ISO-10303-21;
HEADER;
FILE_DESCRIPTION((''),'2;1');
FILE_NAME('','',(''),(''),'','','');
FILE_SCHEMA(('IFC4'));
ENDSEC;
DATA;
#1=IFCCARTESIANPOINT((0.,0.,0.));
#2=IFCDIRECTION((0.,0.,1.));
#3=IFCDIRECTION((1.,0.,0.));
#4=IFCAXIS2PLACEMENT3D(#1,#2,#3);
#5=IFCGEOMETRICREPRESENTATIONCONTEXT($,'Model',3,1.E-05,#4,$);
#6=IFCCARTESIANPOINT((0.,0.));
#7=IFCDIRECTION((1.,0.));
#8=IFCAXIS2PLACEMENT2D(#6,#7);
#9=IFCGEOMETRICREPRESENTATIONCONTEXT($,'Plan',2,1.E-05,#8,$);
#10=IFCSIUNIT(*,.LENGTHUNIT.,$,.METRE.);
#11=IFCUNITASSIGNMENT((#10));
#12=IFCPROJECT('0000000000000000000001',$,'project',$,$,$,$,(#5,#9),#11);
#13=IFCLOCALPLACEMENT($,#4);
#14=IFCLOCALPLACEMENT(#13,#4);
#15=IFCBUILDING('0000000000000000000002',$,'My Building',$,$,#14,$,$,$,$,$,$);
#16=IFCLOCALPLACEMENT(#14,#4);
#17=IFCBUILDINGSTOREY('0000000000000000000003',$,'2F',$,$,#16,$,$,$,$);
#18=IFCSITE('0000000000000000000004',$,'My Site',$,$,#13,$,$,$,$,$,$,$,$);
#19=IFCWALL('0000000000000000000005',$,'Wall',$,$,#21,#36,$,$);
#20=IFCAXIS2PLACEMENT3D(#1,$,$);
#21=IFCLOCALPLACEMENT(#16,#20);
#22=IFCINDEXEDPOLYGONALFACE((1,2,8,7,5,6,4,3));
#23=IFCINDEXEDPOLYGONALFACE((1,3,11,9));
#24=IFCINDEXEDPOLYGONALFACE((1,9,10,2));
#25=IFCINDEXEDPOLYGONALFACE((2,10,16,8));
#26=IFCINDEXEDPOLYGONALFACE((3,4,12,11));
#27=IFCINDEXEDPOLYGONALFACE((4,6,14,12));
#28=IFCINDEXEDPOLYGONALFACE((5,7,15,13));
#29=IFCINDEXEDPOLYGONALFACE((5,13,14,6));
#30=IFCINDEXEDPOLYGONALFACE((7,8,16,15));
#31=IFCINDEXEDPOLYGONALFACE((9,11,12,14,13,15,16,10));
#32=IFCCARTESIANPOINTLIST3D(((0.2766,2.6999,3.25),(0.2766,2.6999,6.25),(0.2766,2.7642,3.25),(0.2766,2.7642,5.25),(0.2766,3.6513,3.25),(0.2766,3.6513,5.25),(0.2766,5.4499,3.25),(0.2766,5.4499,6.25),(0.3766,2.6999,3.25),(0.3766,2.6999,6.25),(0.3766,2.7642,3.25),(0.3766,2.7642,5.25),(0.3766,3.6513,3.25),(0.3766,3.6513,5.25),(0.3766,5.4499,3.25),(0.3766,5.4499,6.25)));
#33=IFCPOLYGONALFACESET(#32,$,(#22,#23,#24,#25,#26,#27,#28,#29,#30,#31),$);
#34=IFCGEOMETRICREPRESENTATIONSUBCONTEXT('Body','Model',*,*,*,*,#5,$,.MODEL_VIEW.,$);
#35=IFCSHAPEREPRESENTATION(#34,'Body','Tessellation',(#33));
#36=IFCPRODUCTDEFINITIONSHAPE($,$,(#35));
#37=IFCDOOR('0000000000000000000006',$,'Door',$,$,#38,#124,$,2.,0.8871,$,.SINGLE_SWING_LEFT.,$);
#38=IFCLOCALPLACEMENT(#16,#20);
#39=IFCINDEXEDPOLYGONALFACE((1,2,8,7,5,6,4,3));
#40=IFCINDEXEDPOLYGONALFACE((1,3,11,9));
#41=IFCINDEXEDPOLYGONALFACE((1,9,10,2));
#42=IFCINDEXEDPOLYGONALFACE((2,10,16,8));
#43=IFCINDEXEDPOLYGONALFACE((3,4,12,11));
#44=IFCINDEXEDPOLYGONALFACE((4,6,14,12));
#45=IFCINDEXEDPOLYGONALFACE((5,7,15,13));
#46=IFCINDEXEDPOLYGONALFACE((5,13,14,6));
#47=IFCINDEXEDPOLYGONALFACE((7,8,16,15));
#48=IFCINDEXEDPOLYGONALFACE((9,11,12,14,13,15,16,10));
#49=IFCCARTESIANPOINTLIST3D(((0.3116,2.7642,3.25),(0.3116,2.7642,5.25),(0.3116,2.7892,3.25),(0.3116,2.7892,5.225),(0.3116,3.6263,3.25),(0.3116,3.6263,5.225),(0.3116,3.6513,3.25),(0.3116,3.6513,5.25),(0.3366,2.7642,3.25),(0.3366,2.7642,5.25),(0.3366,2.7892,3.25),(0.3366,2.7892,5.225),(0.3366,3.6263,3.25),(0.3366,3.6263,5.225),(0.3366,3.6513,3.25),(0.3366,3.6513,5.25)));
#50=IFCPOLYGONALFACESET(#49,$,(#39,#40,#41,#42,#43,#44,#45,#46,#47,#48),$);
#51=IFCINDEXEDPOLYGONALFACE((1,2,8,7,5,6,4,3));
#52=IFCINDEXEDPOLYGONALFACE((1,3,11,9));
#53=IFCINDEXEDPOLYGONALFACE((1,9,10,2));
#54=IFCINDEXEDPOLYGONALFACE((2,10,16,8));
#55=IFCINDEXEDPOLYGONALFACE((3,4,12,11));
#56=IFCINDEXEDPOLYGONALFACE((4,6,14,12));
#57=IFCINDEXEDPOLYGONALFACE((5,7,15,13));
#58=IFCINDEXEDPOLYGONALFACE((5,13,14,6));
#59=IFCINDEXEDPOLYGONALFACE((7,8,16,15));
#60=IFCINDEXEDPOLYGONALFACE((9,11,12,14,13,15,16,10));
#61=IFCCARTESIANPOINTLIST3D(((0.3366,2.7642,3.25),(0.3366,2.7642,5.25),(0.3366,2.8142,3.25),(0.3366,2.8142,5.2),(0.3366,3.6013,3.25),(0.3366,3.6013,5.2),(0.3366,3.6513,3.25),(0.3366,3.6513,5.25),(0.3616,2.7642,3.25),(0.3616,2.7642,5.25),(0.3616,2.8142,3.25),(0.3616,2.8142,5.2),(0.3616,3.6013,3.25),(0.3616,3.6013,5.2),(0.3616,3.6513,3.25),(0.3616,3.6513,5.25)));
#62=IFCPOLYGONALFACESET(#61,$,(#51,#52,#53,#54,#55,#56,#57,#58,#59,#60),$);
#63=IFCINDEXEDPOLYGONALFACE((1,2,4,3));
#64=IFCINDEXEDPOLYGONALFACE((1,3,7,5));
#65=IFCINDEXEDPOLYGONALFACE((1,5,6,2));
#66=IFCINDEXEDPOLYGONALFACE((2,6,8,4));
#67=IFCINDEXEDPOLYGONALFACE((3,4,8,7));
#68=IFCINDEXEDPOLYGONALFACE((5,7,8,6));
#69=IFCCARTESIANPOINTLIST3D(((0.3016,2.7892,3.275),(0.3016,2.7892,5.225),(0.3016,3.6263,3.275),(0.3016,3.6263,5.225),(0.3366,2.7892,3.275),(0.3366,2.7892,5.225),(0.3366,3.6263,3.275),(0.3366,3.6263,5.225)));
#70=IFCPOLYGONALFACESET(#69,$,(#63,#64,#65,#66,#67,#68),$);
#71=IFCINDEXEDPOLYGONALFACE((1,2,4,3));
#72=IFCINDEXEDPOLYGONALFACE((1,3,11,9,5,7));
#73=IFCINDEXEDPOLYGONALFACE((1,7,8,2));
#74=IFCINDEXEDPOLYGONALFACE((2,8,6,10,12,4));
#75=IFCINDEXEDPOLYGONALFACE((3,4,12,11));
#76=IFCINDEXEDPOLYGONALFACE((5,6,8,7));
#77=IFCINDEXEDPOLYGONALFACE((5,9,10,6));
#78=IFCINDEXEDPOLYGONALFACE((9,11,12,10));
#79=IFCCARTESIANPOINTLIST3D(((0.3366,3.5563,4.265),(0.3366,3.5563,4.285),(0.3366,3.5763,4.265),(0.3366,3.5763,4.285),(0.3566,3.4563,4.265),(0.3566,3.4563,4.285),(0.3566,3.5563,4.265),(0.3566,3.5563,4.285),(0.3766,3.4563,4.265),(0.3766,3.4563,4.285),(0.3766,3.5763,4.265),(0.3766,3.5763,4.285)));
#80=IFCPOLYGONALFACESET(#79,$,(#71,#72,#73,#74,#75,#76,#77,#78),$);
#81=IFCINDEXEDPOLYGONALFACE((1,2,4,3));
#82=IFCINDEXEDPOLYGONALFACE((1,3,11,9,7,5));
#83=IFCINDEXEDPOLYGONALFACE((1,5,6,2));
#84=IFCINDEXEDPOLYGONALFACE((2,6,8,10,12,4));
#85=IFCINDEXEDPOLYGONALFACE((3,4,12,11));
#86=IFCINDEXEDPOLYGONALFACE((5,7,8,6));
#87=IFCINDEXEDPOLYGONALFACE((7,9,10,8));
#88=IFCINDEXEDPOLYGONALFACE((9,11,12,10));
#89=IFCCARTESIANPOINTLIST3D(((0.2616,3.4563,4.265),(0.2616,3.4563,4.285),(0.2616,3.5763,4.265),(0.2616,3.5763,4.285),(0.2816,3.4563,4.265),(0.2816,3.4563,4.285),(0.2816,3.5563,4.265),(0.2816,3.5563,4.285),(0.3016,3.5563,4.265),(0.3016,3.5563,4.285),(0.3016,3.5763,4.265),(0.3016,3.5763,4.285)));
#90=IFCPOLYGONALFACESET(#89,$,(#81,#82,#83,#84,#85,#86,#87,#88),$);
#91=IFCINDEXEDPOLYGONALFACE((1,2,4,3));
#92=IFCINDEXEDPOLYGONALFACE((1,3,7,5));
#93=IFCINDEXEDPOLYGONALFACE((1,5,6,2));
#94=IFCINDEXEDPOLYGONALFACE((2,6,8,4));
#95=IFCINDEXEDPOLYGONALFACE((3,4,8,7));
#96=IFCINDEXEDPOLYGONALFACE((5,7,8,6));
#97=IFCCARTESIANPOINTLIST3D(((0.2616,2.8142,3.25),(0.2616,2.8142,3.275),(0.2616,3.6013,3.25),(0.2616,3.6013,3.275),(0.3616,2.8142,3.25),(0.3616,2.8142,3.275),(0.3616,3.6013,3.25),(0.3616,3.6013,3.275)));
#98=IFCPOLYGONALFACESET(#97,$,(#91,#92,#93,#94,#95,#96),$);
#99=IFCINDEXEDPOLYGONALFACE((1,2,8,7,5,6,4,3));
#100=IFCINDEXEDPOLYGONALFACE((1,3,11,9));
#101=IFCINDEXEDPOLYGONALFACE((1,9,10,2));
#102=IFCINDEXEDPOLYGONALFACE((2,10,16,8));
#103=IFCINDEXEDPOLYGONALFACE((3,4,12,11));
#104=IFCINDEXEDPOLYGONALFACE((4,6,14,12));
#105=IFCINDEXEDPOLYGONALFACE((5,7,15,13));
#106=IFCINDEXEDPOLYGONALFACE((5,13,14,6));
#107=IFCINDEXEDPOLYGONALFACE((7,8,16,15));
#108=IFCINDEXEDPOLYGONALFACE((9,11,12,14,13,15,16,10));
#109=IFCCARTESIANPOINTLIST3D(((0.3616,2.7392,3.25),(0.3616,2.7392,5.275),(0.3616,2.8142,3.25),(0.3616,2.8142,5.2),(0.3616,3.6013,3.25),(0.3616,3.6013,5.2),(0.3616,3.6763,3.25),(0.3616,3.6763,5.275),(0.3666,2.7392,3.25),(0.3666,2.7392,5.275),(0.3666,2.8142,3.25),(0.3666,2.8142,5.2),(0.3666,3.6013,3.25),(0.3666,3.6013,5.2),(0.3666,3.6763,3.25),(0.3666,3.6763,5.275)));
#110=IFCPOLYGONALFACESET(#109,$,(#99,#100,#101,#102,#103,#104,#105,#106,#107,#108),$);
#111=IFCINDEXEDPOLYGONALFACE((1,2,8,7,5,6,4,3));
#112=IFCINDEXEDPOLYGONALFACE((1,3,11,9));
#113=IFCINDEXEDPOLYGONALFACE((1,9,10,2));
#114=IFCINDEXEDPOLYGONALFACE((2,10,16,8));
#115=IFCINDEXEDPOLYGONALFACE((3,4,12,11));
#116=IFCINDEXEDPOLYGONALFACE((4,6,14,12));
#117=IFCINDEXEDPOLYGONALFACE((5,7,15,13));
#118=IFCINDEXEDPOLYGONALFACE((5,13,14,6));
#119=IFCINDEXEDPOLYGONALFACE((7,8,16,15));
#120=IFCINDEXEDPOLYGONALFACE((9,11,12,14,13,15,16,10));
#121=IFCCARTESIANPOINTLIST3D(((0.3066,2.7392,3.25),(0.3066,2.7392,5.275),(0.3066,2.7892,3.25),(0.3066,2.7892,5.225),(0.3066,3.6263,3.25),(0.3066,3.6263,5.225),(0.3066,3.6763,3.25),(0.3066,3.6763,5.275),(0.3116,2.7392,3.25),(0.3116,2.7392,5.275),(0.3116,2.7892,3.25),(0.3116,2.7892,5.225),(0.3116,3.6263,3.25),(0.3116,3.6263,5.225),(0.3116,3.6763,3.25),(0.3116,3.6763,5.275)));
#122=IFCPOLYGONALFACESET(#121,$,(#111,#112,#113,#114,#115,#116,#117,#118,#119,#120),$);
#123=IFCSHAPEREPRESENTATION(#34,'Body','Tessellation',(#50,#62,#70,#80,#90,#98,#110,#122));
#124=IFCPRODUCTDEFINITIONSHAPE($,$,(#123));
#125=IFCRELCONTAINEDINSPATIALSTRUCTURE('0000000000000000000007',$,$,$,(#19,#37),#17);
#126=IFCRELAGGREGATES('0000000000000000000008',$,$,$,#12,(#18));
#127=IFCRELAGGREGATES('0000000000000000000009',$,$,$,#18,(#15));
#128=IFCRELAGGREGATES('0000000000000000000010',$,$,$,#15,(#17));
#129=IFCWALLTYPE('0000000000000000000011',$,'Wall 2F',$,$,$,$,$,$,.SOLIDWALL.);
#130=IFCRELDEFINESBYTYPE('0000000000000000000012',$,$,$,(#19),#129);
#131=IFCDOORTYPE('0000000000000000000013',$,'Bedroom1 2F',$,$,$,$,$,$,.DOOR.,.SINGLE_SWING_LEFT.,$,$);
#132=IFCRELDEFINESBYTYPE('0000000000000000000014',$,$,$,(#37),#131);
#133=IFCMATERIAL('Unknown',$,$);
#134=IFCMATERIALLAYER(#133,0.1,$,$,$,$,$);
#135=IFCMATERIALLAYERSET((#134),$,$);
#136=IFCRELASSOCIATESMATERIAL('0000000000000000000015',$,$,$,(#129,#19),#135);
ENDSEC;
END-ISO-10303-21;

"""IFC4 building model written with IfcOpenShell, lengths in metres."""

from ifc_helpers import new_model, entity, si_unit, frame, origin_with_axes, origin_2d_with_axis, place, context, subcontext, project, spatial, line, indexed_curve, outline, extrude, shape, source, transform, mapped, material, layer, layer_set, layer_usage, type_object, type_shapes, element, fill, save


model = new_model("IFC4")

# Units and contexts
model_context = context("Model", 3, precision=1e-05, world=origin_with_axes())
plan_context = context("Plan", 2, precision=1e-05, world=origin_2d_with_axis())
body_context_1 = subcontext(model_context, "Body", "Model", "MODEL_VIEW")
body_context_2 = subcontext(plan_context, "Body", "Plan", "PLAN_VIEW")
ifc_project = project(units=[si_unit("LENGTHUNIT", "METRE")], contexts=[model_context, plan_context])

# Site, building, storey
site_placement = place(None, origin_with_axes())
site = spatial("IfcSite", under=ifc_project, at=site_placement, Name="My Site")
building_placement = place(site_placement, origin_with_axes())
building = spatial("IfcBuilding", under=site, at=building_placement, Name="My Building")
storey_placement = place(building_placement, origin_with_axes())
storey = spatial("IfcBuildingStorey", under=building, at=storey_placement, Name="2F")

# Shared definitions
ifc_material = material(Name="Unknown")

# Shared definitions
ifc_layer = layer(ifc_material, 0.1)
ifc_layer_set = layer_set([ifc_layer])
wall_type = type_object("IfcWallType", Name="Wall 2F", PredefinedType="SOLIDWALL", material=ifc_layer_set)

# Wall, opening, door
ifc_layer_usage_1 = layer_usage(ifc_layer_set, "AXIS2", "POSITIVE", 0.0)
wall_1_placement = place(storey_placement, frame((0.3766, 2.6999, 3.25), z_axis=(0.0, 0.0, 1.0), x_axis=(0.0, 1.0, 0.0)))
wall_1 = element("IfcWall", 1, at=wall_1_placement, inside=storey, type_object=wall_type, material=ifc_layer_usage_1, Name="Wall", context=body_context_1, shape_type="SweptSolid", body=[
    extrude(outline(indexed_curve([(0.0, 0.0), (0.0, 0.1), (2.75, 0.1), (2.75, 0.0)], segments=[line(1, 2, 3, 4, 1)])), origin_with_axes(), (0.0, 0.0, 1.0), 3.0),
])
shared_shape_1 = source(origin_with_axes(), body_context_1, "Body", "SweptSolid", [
    extrude(outline(indexed_curve([(0.0, 0.0), (0.8871, 0.0), (0.8871, 2.0), (0.0, 2.0)], segments=[line(1, 2, 3, 4, 1)])), frame((0.0, -0.6, 0.0), z_axis=(0.0, -1.0, 0.0), x_axis=(1.0, 0.0, 0.0)), (0.0, 0.0, -1.0), 1.2),
])
opening_1_placement = place(wall_1_placement, frame((0.0644, 0.015, 0.0), z_axis=(0.0, 0.0, 1.0), x_axis=(1.0, 0.0, 0.0)))
opening_1 = element("IfcOpeningElement", 2, at=opening_1_placement, cuts=wall_1, PredefinedType="OPENING", context=body_context_1, shape_type="MappedRepresentation", body=[
    mapped(shared_shape_1, transform((0.0, 0.0, 0.0), x_axis=(1.0, 0.0, 0.0), y_axis=(0.0, 1.0, 0.0), z_axis=(0.0, 0.0, 1.0), scale=1.0)),
])
door_type_1 = type_object("IfcDoorType", Name="Bedroom1 2F", OperationType="SINGLE_SWING_LEFT", PredefinedType="DOOR")
shared_shape_2 = source(origin_with_axes(), body_context_1, "Body", "SweptSolid", [
    extrude(outline(indexed_curve([(0.0, 0.0), (0.0, 2.0), (0.8871, 2.0), (0.8871, 0.0), (0.8621, 0.0), (0.8621, 1.975), (0.025, 1.975), (0.025, 0.0)], segments=[line(1, 2, 3, 4, 5, 6, 7, 8, 1)])), frame((0.0, 0.025, 0.0), z_axis=(0.0, -1.0, 0.0), x_axis=(1.0, 0.0, 0.0)), (0.0, 0.0, -1.0), 0.025),
    extrude(outline(indexed_curve([(0.0, 0.0), (0.0, 2.0), (0.8871, 2.0), (0.8871, 0.0), (0.8371, 0.0), (0.8371, 1.95), (0.05, 1.95), (0.05, 0.0)], segments=[line(1, 2, 3, 4, 5, 6, 7, 8, 1)])), frame((0.0, 0.0, 0.0), z_axis=(0.0, -1.0, 0.0), x_axis=(1.0, 0.0, 0.0)), (0.0, 0.0, -1.0), 0.025),
    extrude(outline(indexed_curve([(0.0, 0.0), (0.8371, 0.0), (0.8371, 0.035), (0.0, 0.035)], segments=[line(1, 2, 3, 4, 1)])), frame((0.025, 0.025, 0.025), z_axis=(0.0, 0.0, 1.0), x_axis=(1.0, 0.0, 0.0)), (0.0, 0.0, 1.0), 1.95),
    extrude(outline(indexed_curve([(0.0, 0.0), (0.0, -0.04), (-0.12, -0.04), (-0.12, -0.02), (-0.02, -0.02), (-0.02, 0.0)], segments=[line(1, 2, 3, 4, 5, 6, 1)])), frame((0.8121, 0.025, 1.015), z_axis=(0.0, 0.0, 1.0), x_axis=(1.0, 0.0, 0.0)), (0.0, 0.0, 1.0), 0.02),
    extrude(outline(indexed_curve([(0.0, 0.0), (0.0, 0.04), (-0.12, 0.04), (-0.12, 0.02), (-0.02, 0.02), (-0.02, 0.0)], segments=[line(1, 2, 3, 4, 5, 6, 1)])), frame((0.8121, 0.06, 1.015), z_axis=(0.0, 0.0, 1.0), x_axis=(1.0, 0.0, 0.0)), (0.0, 0.0, 1.0), 0.02),
    extrude(outline(indexed_curve([(0.0, 0.0), (0.7871, 0.0), (0.7871, 0.1), (0.0, 0.1)], segments=[line(1, 2, 3, 4, 1)])), frame((0.05, 0.0, 0.0), z_axis=(0.0, 0.0, 1.0), x_axis=(1.0, 0.0, 0.0)), (0.0, 0.0, 1.0), 0.025),
    extrude(outline(indexed_curve([(0.0, 0.0), (0.0, 2.025), (0.9371, 2.025), (0.9371, 0.0), (0.8621, 0.0), (0.8621, 1.95), (0.075, 1.95), (0.075, 0.0)], segments=[line(1, 2, 3, 4, 5, 6, 7, 8, 1)])), frame((-0.025, -0.005, 0.0), z_axis=(0.0, -1.0, 0.0), x_axis=(1.0, 0.0, 0.0)), (0.0, 0.0, -1.0), 0.005),
    extrude(outline(indexed_curve([(0.0, 0.0), (0.0, 2.025), (0.9371, 2.025), (0.9371, 0.0), (0.8871, 0.0), (0.8871, 1.975), (0.05, 1.975), (0.05, 0.0)], segments=[line(1, 2, 3, 4, 5, 6, 7, 8, 1)])), frame((-0.025, 0.05, 0.0), z_axis=(0.0, -1.0, 0.0), x_axis=(1.0, 0.0, 0.0)), (0.0, 0.0, -1.0), 0.005),
])
shared_shape_3 = source(origin_with_axes(), body_context_2, "Body", "Curve2D", [
    entity("IfcIndexedPolyCurve", entity("IfcCartesianPointList2D", [[0.0, 0.0], [0.0, 0.05], [0.025, 0.05], [0.025, 0.025], [0.05, 0.025], [0.05, 0.0]]), [entity("IfcLineIndex", [1, 2, 3, 4, 5, 6, 1])]),
    entity("IfcIndexedPolyCurve", entity("IfcCartesianPointList2D", [[0.8871, 0.0], [0.8871, 0.05], [0.8621, 0.05], [0.8621, 0.025], [0.8371, 0.025], [0.8371, 0.0]]), [entity("IfcLineIndex", [1, 2, 3, 4, 5, 6, 1])]),
    entity("IfcTrimmedCurve", entity("IfcEllipse", entity("IfcAxis2Placement2D", entity("IfcCartesianPoint", [0.06, 0.05]), entity("IfcDirection", [1.0, 0.0])), 0.8021, 0.8371), [entity("IfcCartesianPoint", [0.8621, 0.05])], [entity("IfcCartesianPoint", [0.06, 0.8871])], True, "CARTESIAN"),
    entity("IfcIndexedPolyCurve", entity("IfcCartesianPointList2D", [[0.025, 0.05], [0.06, 0.05], [0.06, 0.8871], [0.025, 0.8871]]), [entity("IfcLineIndex", [1, 2, 3, 4, 1])]),
])
type_shapes(door_type_1, [shared_shape_2, shared_shape_3])
door_1_placement = place(opening_1_placement, frame((0.0, 0.0, 0.0), z_axis=(0.0, 0.0, 1.0), x_axis=(1.0, 0.0, 0.0)))
door_1 = element("IfcDoor", 3, at=door_1_placement, inside=storey, type_object=door_type_1, Name="Door", OperationType="SINGLE_SWING_LEFT", OverallHeight=2.0, OverallWidth=0.8871, shapes=[
    shape(body_context_1, "Body", "MappedRepresentation", [mapped(shared_shape_2, transform((0.0, 0.0, 0.0), x_axis=(1.0, 0.0, 0.0), y_axis=(0.0, 1.0, 0.0), z_axis=(0.0, 0.0, 1.0), scale=1.0))]),
    shape(body_context_2, "Body", "MappedRepresentation", [mapped(shared_shape_3, transform((0.0, 0.0, 0.0), x_axis=(1.0, 0.0, 0.0), y_axis=(0.0, 1.0, 0.0), z_axis=(0.0, 0.0, 1.0), scale=1.0))]),
])
fill(opening_1, door_1)

save(model, "model.ifc")
